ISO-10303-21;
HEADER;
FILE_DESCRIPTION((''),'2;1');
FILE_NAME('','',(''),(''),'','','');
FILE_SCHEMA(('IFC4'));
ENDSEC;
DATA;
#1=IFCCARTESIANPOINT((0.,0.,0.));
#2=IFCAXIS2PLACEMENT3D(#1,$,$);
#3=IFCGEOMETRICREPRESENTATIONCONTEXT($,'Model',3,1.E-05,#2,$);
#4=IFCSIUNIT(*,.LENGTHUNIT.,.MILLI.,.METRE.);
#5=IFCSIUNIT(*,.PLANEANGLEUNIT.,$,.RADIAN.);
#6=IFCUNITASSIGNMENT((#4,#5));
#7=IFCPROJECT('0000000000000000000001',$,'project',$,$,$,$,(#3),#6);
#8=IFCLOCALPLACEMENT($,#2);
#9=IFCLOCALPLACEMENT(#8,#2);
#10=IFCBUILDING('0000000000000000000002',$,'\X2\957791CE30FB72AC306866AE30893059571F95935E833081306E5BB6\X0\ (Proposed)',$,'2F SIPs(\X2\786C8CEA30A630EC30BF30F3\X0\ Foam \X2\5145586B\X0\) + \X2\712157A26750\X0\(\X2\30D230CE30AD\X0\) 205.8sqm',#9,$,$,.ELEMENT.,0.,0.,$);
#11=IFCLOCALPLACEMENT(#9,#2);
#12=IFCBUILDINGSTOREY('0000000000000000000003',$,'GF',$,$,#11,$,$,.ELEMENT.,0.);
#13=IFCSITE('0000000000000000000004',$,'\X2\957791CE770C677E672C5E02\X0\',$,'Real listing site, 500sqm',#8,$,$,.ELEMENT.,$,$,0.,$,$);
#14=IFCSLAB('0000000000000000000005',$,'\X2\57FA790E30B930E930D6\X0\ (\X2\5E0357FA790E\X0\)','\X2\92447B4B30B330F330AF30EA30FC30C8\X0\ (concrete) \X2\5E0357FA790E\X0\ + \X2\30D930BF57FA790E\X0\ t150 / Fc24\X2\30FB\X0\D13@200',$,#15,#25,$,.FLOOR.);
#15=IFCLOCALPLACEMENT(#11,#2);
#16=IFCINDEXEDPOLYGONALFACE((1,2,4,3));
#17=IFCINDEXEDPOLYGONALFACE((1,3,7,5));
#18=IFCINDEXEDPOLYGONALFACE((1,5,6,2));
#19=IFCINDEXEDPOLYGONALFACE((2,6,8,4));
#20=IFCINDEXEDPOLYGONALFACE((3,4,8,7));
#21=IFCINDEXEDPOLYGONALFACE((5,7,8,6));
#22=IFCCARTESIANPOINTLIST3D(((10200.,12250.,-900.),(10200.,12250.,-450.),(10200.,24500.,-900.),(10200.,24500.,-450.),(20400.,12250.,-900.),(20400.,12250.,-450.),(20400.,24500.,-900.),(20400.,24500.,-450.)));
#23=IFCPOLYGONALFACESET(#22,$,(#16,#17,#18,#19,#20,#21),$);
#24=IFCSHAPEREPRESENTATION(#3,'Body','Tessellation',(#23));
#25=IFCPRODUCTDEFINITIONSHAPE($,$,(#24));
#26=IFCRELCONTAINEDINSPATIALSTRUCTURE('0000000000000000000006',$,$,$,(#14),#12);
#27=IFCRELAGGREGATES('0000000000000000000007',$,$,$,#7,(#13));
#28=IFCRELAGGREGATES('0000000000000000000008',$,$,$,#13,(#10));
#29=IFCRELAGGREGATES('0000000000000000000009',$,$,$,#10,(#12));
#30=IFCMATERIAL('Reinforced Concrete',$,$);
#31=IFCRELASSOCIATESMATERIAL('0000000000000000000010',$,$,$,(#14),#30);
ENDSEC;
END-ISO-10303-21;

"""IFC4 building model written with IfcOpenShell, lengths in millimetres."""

from ifc_helpers import new_model, si_unit, frame, frame_2d, origin, place, context, project, spatial, rectangle, extrude, material, element, save


model = new_model("IFC4")

# Units and contexts
model_context = context("Model", 3, precision=1e-05, world=origin())
ifc_project = project(units=[si_unit("LENGTHUNIT", "METRE", prefix="MILLI"), si_unit("PLANEANGLEUNIT", "RADIAN")], contexts=[model_context])

# Site, building, storey
site_placement = place(None, origin())
site = spatial("IfcSite", under=ifc_project, at=site_placement, Name="長野県松本市", ObjectType="Real listing site, 500sqm", CompositionType="ELEMENT", RefElevation=0.0)
building_placement = place(site_placement, origin())
building = spatial("IfcBuilding", under=site, at=building_placement, Name="長野・犬と暮らす土間広めの家 (Proposed)", ObjectType="2F SIPs(硬質ウレタン Foam 充填) + 無垢材(ヒノキ) 205.8sqm", CompositionType="ELEMENT", ElevationOfRefHeight=0.0, ElevationOfTerrain=0.0)
storey_placement = place(building_placement, origin())
storey = spatial("IfcBuildingStorey", under=building, at=storey_placement, Name="GF", CompositionType="ELEMENT", Elevation=0.0)

# Slab
ifc_material_1 = material(Name="Reinforced Concrete")
slab_1_placement = place(storey_placement, frame((5100.0, 6125.0, -450.0)))
element("IfcSlab", 1, at=slab_1_placement, inside=storey, material=ifc_material_1, Name="基礎スラブ (布基礎)", Description="鉄筋コンクリート (concrete) 布基礎 + ベタ基礎 t150 / Fc24・D13@200", PredefinedType="FLOOR", context=model_context, shape_type="SweptSolid", body=[
    extrude(rectangle(XDim=10200.0, YDim=12250.0, at=frame_2d((5100.0, 6125.0))), frame((5100.0, 6125.0, -450.0)), (0.0, 0.0, 1.0), 450.0),
])

save(model, "model.ifc")
